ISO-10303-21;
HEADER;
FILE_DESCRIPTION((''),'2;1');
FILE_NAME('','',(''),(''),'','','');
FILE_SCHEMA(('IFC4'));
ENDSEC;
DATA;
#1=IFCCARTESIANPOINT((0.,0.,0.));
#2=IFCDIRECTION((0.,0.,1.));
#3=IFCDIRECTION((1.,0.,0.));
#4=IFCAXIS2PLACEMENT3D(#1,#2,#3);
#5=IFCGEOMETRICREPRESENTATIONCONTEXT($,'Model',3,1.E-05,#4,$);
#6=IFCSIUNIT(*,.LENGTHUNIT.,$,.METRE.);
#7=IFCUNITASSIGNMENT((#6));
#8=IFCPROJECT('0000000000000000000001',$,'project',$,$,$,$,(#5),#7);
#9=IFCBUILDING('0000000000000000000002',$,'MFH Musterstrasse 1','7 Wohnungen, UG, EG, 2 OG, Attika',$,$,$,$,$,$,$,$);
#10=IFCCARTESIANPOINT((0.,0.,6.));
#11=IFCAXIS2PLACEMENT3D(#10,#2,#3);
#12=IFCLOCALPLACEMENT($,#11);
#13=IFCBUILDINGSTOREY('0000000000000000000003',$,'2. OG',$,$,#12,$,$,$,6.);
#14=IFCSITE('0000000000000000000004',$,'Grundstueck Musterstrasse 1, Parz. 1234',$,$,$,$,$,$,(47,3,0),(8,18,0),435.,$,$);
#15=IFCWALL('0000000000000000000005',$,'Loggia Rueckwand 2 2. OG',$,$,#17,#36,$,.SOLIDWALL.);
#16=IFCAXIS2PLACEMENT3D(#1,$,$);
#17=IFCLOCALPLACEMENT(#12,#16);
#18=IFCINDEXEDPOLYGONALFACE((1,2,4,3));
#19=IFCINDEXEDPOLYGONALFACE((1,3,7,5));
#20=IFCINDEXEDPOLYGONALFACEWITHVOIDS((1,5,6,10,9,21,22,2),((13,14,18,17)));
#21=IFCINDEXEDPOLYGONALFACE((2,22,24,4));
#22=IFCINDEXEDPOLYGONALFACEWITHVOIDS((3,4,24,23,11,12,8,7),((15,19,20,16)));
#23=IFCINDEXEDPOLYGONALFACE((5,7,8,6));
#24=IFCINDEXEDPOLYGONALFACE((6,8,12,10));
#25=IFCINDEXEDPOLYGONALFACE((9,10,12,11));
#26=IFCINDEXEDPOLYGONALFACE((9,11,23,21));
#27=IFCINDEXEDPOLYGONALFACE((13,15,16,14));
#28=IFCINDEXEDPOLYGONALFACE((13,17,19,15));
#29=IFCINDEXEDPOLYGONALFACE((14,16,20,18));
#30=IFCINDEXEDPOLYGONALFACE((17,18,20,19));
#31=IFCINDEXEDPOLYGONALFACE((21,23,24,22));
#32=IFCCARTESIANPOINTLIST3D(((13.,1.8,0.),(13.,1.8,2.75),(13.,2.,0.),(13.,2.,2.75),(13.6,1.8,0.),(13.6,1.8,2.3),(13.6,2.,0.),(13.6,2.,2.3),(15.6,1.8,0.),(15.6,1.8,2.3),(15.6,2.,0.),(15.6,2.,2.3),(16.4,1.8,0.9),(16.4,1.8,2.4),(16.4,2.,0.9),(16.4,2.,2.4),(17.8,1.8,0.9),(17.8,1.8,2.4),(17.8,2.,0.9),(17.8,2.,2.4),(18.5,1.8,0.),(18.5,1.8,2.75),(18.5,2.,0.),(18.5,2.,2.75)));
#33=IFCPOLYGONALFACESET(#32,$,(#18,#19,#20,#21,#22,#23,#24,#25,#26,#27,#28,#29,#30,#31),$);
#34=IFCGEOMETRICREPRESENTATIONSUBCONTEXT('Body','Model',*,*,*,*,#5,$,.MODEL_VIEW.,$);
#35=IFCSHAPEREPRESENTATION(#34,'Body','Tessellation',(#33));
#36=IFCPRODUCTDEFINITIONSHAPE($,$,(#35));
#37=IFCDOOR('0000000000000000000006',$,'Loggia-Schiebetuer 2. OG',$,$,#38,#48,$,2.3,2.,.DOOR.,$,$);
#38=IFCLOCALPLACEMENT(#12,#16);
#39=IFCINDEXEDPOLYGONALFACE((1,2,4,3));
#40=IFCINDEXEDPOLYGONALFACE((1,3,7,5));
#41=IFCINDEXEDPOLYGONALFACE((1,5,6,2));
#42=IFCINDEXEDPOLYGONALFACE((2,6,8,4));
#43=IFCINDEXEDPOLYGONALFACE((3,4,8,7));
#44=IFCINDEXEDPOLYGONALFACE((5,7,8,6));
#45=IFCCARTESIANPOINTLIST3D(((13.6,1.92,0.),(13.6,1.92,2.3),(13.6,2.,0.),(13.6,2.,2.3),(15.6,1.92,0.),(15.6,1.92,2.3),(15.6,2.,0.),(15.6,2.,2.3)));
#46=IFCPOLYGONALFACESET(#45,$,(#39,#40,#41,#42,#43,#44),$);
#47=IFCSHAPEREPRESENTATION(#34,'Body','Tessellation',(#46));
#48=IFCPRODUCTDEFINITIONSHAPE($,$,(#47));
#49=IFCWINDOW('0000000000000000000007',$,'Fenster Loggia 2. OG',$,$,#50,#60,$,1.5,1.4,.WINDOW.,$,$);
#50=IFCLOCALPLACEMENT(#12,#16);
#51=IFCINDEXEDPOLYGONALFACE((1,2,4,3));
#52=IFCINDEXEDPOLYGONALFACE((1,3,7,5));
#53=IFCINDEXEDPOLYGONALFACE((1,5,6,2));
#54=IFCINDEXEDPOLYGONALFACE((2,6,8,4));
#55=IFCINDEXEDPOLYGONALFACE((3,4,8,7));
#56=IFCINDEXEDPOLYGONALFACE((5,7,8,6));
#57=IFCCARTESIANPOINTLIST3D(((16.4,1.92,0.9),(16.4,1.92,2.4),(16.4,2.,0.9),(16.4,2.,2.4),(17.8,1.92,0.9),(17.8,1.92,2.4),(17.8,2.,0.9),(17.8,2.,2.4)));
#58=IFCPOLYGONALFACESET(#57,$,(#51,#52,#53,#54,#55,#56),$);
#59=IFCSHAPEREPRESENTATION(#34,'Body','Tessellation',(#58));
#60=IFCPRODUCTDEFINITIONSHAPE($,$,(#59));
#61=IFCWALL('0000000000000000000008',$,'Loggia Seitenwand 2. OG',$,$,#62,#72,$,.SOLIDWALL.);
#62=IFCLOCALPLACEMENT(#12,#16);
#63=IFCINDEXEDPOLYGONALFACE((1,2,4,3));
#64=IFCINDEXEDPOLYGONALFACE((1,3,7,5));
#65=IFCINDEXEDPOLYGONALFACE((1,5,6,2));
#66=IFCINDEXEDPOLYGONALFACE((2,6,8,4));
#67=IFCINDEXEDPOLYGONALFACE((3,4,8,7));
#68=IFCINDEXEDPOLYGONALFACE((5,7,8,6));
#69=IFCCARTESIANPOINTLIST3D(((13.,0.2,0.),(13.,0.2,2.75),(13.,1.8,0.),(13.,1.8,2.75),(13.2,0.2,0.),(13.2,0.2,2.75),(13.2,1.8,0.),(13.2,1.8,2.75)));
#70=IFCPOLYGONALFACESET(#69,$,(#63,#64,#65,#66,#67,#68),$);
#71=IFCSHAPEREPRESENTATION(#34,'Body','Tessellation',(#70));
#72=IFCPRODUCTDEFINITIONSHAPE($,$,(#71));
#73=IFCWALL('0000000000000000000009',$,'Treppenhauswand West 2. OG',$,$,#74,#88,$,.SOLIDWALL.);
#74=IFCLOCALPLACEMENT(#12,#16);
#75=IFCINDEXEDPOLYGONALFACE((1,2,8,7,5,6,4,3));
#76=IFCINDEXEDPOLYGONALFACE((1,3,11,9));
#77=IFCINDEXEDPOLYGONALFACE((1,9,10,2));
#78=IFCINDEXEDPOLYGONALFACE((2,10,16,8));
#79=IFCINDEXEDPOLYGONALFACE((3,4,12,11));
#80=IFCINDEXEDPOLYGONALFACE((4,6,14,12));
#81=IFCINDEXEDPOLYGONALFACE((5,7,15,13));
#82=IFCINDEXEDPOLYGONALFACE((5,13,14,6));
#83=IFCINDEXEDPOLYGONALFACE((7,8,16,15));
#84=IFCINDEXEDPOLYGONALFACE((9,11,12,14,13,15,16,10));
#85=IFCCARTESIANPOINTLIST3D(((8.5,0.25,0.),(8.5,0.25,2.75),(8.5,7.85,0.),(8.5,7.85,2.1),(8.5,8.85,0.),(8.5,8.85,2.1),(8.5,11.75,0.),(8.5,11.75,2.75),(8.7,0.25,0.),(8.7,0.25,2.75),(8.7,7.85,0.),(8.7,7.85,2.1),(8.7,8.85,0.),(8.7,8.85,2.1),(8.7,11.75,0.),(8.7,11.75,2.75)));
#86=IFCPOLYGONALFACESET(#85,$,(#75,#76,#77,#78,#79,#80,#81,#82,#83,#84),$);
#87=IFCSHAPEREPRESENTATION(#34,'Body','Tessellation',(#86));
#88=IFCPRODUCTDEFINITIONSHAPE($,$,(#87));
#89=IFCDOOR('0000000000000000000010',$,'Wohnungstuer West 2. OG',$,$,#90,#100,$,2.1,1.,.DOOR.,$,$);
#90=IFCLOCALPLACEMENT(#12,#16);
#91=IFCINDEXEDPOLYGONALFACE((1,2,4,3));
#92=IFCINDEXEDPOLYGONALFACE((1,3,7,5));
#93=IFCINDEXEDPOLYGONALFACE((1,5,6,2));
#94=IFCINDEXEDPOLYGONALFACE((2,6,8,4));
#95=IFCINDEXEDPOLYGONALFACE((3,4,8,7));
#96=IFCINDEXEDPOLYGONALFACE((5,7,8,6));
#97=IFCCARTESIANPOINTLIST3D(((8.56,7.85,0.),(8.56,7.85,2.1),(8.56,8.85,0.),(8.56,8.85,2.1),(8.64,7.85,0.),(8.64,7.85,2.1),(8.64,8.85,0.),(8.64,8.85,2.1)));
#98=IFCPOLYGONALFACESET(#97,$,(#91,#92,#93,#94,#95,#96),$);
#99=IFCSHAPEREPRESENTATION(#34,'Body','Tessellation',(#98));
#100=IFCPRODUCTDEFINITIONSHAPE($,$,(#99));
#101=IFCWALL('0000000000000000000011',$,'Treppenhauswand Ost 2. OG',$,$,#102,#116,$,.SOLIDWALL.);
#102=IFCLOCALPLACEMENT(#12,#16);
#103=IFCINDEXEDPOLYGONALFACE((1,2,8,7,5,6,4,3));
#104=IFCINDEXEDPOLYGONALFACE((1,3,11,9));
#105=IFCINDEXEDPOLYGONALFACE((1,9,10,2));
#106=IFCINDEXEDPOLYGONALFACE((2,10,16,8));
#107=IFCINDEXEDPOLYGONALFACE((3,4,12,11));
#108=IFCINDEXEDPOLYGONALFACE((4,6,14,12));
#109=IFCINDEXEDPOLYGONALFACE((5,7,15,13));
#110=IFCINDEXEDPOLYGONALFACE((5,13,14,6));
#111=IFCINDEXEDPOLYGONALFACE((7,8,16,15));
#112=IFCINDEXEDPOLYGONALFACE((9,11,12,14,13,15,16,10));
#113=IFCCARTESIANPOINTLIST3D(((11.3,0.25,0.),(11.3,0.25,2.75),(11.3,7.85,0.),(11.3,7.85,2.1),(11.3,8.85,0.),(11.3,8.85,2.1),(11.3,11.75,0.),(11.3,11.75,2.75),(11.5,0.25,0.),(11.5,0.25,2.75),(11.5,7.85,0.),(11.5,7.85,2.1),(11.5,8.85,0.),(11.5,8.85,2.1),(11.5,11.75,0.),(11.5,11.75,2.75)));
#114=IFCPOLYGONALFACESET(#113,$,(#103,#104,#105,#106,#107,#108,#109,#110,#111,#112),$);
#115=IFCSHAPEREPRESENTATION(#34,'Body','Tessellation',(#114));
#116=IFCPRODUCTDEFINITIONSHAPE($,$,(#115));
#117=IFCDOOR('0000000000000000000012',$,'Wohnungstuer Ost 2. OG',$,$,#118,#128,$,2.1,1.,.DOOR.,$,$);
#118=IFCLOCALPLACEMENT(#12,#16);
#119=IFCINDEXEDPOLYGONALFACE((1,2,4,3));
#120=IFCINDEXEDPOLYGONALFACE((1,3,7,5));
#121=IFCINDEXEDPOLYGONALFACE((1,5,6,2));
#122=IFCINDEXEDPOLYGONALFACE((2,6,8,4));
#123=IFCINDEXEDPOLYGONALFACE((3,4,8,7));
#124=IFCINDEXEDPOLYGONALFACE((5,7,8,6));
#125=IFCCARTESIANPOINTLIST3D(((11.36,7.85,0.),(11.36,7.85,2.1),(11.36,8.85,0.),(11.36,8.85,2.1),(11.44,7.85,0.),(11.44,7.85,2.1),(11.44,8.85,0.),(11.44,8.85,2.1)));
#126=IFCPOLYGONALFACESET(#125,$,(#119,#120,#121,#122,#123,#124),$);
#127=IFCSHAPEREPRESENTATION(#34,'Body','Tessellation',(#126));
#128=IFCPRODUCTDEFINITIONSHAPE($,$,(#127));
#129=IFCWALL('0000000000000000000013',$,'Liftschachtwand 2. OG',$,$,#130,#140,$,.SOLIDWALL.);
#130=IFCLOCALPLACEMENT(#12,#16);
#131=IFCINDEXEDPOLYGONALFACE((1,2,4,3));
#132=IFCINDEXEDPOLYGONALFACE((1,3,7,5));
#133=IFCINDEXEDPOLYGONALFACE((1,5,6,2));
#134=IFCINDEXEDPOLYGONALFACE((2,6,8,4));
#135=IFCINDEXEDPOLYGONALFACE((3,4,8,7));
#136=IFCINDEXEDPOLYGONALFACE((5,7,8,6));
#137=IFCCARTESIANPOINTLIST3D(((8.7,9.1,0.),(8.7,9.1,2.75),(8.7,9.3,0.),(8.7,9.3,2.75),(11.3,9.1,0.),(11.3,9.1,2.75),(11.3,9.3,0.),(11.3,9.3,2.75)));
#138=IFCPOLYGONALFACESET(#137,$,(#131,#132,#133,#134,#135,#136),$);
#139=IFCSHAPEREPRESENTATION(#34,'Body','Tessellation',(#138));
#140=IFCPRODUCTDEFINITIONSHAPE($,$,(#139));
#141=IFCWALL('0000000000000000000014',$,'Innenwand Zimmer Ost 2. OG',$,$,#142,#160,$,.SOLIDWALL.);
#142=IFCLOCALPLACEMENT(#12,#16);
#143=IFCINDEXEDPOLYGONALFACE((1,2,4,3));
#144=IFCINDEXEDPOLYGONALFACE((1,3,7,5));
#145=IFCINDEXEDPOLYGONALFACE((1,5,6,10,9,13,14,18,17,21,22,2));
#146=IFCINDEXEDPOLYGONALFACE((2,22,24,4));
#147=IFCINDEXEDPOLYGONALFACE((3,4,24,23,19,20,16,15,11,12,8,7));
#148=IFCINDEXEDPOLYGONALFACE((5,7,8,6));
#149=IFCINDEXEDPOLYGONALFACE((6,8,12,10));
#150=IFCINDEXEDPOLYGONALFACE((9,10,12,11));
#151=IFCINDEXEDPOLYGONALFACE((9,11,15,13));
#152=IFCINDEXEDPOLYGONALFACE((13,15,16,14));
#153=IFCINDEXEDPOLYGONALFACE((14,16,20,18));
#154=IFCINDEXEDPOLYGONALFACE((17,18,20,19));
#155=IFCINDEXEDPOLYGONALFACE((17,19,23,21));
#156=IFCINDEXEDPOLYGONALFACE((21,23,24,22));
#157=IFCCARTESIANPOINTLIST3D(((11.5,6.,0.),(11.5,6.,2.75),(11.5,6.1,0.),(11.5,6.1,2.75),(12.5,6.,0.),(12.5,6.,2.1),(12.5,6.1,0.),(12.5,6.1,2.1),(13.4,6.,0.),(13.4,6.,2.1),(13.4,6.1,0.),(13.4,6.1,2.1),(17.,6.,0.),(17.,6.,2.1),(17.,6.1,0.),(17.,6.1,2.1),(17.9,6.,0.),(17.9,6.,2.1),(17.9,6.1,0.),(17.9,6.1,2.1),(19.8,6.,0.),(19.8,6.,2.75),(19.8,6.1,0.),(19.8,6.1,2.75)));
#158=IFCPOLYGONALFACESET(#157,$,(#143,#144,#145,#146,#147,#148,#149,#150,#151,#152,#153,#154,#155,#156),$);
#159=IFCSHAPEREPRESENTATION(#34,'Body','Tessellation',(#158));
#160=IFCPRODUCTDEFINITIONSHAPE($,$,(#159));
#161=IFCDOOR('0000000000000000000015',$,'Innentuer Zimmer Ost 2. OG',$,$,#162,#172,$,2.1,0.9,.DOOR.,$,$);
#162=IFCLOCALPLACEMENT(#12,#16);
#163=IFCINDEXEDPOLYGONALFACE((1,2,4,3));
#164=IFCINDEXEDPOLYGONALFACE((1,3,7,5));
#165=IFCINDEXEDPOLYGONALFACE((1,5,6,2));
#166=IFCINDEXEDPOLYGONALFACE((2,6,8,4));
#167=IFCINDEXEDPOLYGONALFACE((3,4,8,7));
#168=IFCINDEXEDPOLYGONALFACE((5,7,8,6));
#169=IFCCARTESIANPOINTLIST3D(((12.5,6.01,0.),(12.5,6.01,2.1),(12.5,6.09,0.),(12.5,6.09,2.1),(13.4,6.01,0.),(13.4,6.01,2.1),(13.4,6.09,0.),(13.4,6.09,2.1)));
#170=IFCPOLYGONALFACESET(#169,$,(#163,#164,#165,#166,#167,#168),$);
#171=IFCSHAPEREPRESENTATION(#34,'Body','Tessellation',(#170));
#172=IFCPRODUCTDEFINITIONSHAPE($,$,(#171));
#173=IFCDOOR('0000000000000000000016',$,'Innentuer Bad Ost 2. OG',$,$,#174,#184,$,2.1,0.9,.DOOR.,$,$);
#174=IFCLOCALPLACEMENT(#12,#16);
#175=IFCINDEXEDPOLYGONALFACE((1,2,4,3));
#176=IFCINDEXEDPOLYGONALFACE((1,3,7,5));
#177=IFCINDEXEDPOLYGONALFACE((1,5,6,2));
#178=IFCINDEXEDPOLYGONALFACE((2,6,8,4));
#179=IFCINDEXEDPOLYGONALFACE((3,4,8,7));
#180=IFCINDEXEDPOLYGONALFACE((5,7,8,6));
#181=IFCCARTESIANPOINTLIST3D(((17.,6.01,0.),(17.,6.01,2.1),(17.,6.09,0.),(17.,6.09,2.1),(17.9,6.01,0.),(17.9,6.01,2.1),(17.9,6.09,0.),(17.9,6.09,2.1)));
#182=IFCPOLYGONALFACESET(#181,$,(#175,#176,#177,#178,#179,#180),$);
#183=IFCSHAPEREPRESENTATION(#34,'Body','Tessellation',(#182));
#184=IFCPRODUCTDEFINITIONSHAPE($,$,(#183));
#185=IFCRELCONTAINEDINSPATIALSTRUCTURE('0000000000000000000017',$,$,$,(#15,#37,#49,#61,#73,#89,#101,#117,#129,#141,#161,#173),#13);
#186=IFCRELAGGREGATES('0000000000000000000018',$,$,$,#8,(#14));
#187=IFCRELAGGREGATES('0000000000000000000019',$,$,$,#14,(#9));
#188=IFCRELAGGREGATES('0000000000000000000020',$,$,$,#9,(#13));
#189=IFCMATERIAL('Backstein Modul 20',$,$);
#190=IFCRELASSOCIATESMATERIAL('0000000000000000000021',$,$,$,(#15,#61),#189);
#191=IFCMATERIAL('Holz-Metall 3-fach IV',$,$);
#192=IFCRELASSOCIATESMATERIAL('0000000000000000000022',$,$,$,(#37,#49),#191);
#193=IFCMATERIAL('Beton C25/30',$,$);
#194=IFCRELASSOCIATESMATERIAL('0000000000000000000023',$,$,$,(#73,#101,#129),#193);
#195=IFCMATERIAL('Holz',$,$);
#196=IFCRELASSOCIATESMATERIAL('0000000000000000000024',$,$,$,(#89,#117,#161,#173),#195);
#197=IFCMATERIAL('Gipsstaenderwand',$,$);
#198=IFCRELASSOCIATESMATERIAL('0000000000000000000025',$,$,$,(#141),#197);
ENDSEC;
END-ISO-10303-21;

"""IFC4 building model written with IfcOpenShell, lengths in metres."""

from ifc_helpers import new_model, si_unit, frame, frame_2d, origin_with_axes, place, context, subcontext, project, spatial, rectangle, extrude, material, element, fill, save


model = new_model("IFC4")

# Units and contexts
model_context = context("Model", 3, precision=1e-05, world=origin_with_axes())
body_context = subcontext(model_context, "Body", "Model", "MODEL_VIEW")
ifc_project = project(units=[si_unit("LENGTHUNIT", "METRE")], contexts=[model_context])

# Site, building, storey
site = spatial("IfcSite", under=ifc_project, Name="Grundstueck Musterstrasse 1, Parz. 1234", RefLatitude=(47, 3, 0), RefLongitude=(8, 18, 0), RefElevation=435.0)
building = spatial("IfcBuilding", under=site, Name="MFH Musterstrasse 1", Description="7 Wohnungen, UG, EG, 2 OG, Attika")
storey_placement = place(None, frame((0.0, 0.0, 6.0), z_axis=(0.0, 0.0, 1.0), x_axis=(1.0, 0.0, 0.0)))
storey = spatial("IfcBuildingStorey", under=building, at=storey_placement, Name="2. OG", Elevation=6.0)

# Wall, openings, door, window
ifc_material_1 = material(Name="Backstein Modul 20")
wall_1_placement = place(storey_placement, frame((13.0, 1.8, 0.0), z_axis=(0.0, 0.0, 1.0), x_axis=(1.0, 0.0, 0.0)))
wall_1 = element("IfcWall", 1, at=wall_1_placement, inside=storey, material=ifc_material_1, Name="Loggia Rueckwand 2 2. OG", PredefinedType="SOLIDWALL", context=body_context, shape_type="SweptSolid", body=[
    extrude(rectangle(XDim=5.5, YDim=0.2, at=frame_2d((2.75, 0.1))), origin_with_axes(), (0.0, 0.0, 1.0), 2.75),
])
opening_1_placement = place(wall_1_placement, frame((0.6, -0.21, 0.0), z_axis=(0.0, 0.0, 1.0), x_axis=(1.0, 0.0, 0.0)))
opening_1 = element("IfcOpeningElement", 2, at=opening_1_placement, cuts=wall_1, context=body_context, shape_type="SweptSolid", body=[
    extrude(rectangle(XDim=2.0, YDim=0.42, at=frame_2d((1.0, 0.21))), origin_with_axes(), (0.0, 0.0, 1.0), 2.3),
])
opening_2_placement = place(wall_1_placement, frame((3.4, -0.21, 0.9), z_axis=(0.0, 0.0, 1.0), x_axis=(1.0, 0.0, 0.0)))
opening_2 = element("IfcOpeningElement", 3, at=opening_2_placement, cuts=wall_1, context=body_context, shape_type="SweptSolid", body=[
    extrude(rectangle(XDim=1.4, YDim=0.42, at=frame_2d((0.7, 0.21))), origin_with_axes(), (0.0, 0.0, 1.0), 1.5),
])
ifc_material_2 = material(Name="Holz-Metall 3-fach IV")
door_1_placement = place(storey_placement, frame((13.6, 1.92, 0.0), z_axis=(0.0, 0.0, 1.0), x_axis=(1.0, 0.0, 0.0)))
door_1 = element("IfcDoor", 4, at=door_1_placement, inside=storey, material=ifc_material_2, Name="Loggia-Schiebetuer 2. OG", OverallHeight=2.3, OverallWidth=2.0, PredefinedType="DOOR", context=body_context, shape_type="SweptSolid", body=[
    extrude(rectangle(XDim=2.0, YDim=0.08, at=frame_2d((1.0, 0.04))), origin_with_axes(), (0.0, 0.0, 1.0), 2.3),
])
fill(opening_1, door_1)
window_placement = place(storey_placement, frame((16.4, 1.92, 0.9), z_axis=(0.0, 0.0, 1.0), x_axis=(1.0, 0.0, 0.0)))
window = element("IfcWindow", 5, at=window_placement, inside=storey, material=ifc_material_2, Name="Fenster Loggia 2. OG", OverallHeight=1.5, OverallWidth=1.4, PredefinedType="WINDOW", context=body_context, shape_type="SweptSolid", body=[
    extrude(rectangle(XDim=1.4, YDim=0.08, at=frame_2d((0.7, 0.04))), origin_with_axes(), (0.0, 0.0, 1.0), 1.5),
])
fill(opening_2, window)

# Wall
wall_2_placement = place(storey_placement, frame((13.0, 0.2, 0.0), z_axis=(0.0, 0.0, 1.0), x_axis=(1.0, 0.0, 0.0)))
element("IfcWall", 6, at=wall_2_placement, inside=storey, material=ifc_material_1, Name="Loggia Seitenwand 2. OG", PredefinedType="SOLIDWALL", context=body_context, shape_type="SweptSolid", body=[
    extrude(rectangle(XDim=0.2, YDim=1.6, at=frame_2d((0.1, 0.8))), origin_with_axes(), (0.0, 0.0, 1.0), 2.75),
])

# Walls, openings, doors
ifc_material_3 = material(Name="Beton C25/30")
wall_3_placement = place(storey_placement, frame((8.5, 0.25, 0.0), z_axis=(0.0, 0.0, 1.0), x_axis=(1.0, 0.0, 0.0)))
wall_3 = element("IfcWall", 7, at=wall_3_placement, inside=storey, material=ifc_material_3, Name="Treppenhauswand West 2. OG", PredefinedType="SOLIDWALL", context=body_context, shape_type="SweptSolid", body=[
    extrude(rectangle(XDim=0.2, YDim=11.5, at=frame_2d((0.1, 5.75))), origin_with_axes(), (0.0, 0.0, 1.0), 2.75),
])
opening_3_placement = place(wall_3_placement, frame((-0.01, 7.6, 0.0), z_axis=(0.0, 0.0, 1.0), x_axis=(1.0, 0.0, 0.0)))
opening_3 = element("IfcOpeningElement", 8, at=opening_3_placement, cuts=wall_3, context=body_context, shape_type="SweptSolid", body=[
    extrude(rectangle(XDim=0.22, YDim=1.0, at=frame_2d((0.11, 0.5))), origin_with_axes(), (0.0, 0.0, 1.0), 2.1),
])
ifc_material_4 = material(Name="Holz")
door_2_placement = place(storey_placement, frame((8.56, 7.85, 0.0), z_axis=(0.0, 0.0, 1.0), x_axis=(1.0, 0.0, 0.0)))
door_2 = element("IfcDoor", 9, at=door_2_placement, inside=storey, material=ifc_material_4, Name="Wohnungstuer West 2. OG", OverallHeight=2.1, OverallWidth=1.0, PredefinedType="DOOR", context=body_context, shape_type="SweptSolid", body=[
    extrude(rectangle(XDim=0.08, YDim=1.0, at=frame_2d((0.04, 0.5))), origin_with_axes(), (0.0, 0.0, 1.0), 2.1),
])
fill(opening_3, door_2)
wall_4_placement = place(storey_placement, frame((11.3, 0.25, 0.0), z_axis=(0.0, 0.0, 1.0), x_axis=(1.0, 0.0, 0.0)))
wall_4 = element("IfcWall", 10, at=wall_4_placement, inside=storey, material=ifc_material_3, Name="Treppenhauswand Ost 2. OG", PredefinedType="SOLIDWALL", context=body_context, shape_type="SweptSolid", body=[
    extrude(rectangle(XDim=0.2, YDim=11.5, at=frame_2d((0.1, 5.75))), origin_with_axes(), (0.0, 0.0, 1.0), 2.75),
])
opening_4_placement = place(wall_4_placement, frame((-0.01, 7.6, 0.0), z_axis=(0.0, 0.0, 1.0), x_axis=(1.0, 0.0, 0.0)))
opening_4 = element("IfcOpeningElement", 11, at=opening_4_placement, cuts=wall_4, context=body_context, shape_type="SweptSolid", body=[
    extrude(rectangle(XDim=0.22, YDim=1.0, at=frame_2d((0.11, 0.5))), origin_with_axes(), (0.0, 0.0, 1.0), 2.1),
])
door_3_placement = place(storey_placement, frame((11.36, 7.85, 0.0), z_axis=(0.0, 0.0, 1.0), x_axis=(1.0, 0.0, 0.0)))
door_3 = element("IfcDoor", 12, at=door_3_placement, inside=storey, material=ifc_material_4, Name="Wohnungstuer Ost 2. OG", OverallHeight=2.1, OverallWidth=1.0, PredefinedType="DOOR", context=body_context, shape_type="SweptSolid", body=[
    extrude(rectangle(XDim=0.08, YDim=1.0, at=frame_2d((0.04, 0.5))), origin_with_axes(), (0.0, 0.0, 1.0), 2.1),
])
fill(opening_4, door_3)

# Wall
wall_5_placement = place(storey_placement, frame((8.7, 9.1, 0.0), z_axis=(0.0, 0.0, 1.0), x_axis=(1.0, 0.0, 0.0)))
element("IfcWall", 13, at=wall_5_placement, inside=storey, material=ifc_material_3, Name="Liftschachtwand 2. OG", PredefinedType="SOLIDWALL", context=body_context, shape_type="SweptSolid", body=[
    extrude(rectangle(XDim=2.6, YDim=0.2, at=frame_2d((1.3, 0.1))), origin_with_axes(), (0.0, 0.0, 1.0), 2.75),
])

# Wall, openings, doors
ifc_material_5 = material(Name="Gipsstaenderwand")
wall_6_placement = place(storey_placement, frame((11.5, 6.0, 0.0), z_axis=(0.0, 0.0, 1.0), x_axis=(1.0, 0.0, 0.0)))
wall_6 = element("IfcWall", 14, at=wall_6_placement, inside=storey, material=ifc_material_5, Name="Innenwand Zimmer Ost 2. OG", PredefinedType="SOLIDWALL", context=body_context, shape_type="SweptSolid", body=[
    extrude(rectangle(XDim=8.3, YDim=0.1, at=frame_2d((4.15, 0.05))), origin_with_axes(), (0.0, 0.0, 1.0), 2.75),
])
opening_5_placement = place(wall_6_placement, frame((1.0, -0.01, 0.0), z_axis=(0.0, 0.0, 1.0), x_axis=(1.0, 0.0, 0.0)))
opening_5 = element("IfcOpeningElement", 15, at=opening_5_placement, cuts=wall_6, context=body_context, shape_type="SweptSolid", body=[
    extrude(rectangle(XDim=0.9, YDim=0.12, at=frame_2d((0.45, 0.06))), origin_with_axes(), (0.0, 0.0, 1.0), 2.1),
])
opening_6_placement = place(wall_6_placement, frame((5.5, -0.01, 0.0), z_axis=(0.0, 0.0, 1.0), x_axis=(1.0, 0.0, 0.0)))
opening_6 = element("IfcOpeningElement", 16, at=opening_6_placement, cuts=wall_6, context=body_context, shape_type="SweptSolid", body=[
    extrude(rectangle(XDim=0.9, YDim=0.12, at=frame_2d((0.45, 0.06))), origin_with_axes(), (0.0, 0.0, 1.0), 2.1),
])
door_4_placement = place(storey_placement, frame((12.5, 6.01, 0.0), z_axis=(0.0, 0.0, 1.0), x_axis=(1.0, 0.0, 0.0)))
door_4 = element("IfcDoor", 17, at=door_4_placement, inside=storey, material=ifc_material_4, Name="Innentuer Zimmer Ost 2. OG", OverallHeight=2.1, OverallWidth=0.9, PredefinedType="DOOR", context=body_context, shape_type="SweptSolid", body=[
    extrude(rectangle(XDim=0.9, YDim=0.08, at=frame_2d((0.45, 0.04))), origin_with_axes(), (0.0, 0.0, 1.0), 2.1),
])
fill(opening_5, door_4)
door_5_placement = place(storey_placement, frame((17.0, 6.01, 0.0), z_axis=(0.0, 0.0, 1.0), x_axis=(1.0, 0.0, 0.0)))
door_5 = element("IfcDoor", 18, at=door_5_placement, inside=storey, material=ifc_material_4, Name="Innentuer Bad Ost 2. OG", OverallHeight=2.1, OverallWidth=0.9, PredefinedType="DOOR", context=body_context, shape_type="SweptSolid", body=[
    extrude(rectangle(XDim=0.9, YDim=0.08, at=frame_2d((0.45, 0.04))), origin_with_axes(), (0.0, 0.0, 1.0), 2.1),
])
fill(opening_6, door_5)

save(model, "model.ifc")
